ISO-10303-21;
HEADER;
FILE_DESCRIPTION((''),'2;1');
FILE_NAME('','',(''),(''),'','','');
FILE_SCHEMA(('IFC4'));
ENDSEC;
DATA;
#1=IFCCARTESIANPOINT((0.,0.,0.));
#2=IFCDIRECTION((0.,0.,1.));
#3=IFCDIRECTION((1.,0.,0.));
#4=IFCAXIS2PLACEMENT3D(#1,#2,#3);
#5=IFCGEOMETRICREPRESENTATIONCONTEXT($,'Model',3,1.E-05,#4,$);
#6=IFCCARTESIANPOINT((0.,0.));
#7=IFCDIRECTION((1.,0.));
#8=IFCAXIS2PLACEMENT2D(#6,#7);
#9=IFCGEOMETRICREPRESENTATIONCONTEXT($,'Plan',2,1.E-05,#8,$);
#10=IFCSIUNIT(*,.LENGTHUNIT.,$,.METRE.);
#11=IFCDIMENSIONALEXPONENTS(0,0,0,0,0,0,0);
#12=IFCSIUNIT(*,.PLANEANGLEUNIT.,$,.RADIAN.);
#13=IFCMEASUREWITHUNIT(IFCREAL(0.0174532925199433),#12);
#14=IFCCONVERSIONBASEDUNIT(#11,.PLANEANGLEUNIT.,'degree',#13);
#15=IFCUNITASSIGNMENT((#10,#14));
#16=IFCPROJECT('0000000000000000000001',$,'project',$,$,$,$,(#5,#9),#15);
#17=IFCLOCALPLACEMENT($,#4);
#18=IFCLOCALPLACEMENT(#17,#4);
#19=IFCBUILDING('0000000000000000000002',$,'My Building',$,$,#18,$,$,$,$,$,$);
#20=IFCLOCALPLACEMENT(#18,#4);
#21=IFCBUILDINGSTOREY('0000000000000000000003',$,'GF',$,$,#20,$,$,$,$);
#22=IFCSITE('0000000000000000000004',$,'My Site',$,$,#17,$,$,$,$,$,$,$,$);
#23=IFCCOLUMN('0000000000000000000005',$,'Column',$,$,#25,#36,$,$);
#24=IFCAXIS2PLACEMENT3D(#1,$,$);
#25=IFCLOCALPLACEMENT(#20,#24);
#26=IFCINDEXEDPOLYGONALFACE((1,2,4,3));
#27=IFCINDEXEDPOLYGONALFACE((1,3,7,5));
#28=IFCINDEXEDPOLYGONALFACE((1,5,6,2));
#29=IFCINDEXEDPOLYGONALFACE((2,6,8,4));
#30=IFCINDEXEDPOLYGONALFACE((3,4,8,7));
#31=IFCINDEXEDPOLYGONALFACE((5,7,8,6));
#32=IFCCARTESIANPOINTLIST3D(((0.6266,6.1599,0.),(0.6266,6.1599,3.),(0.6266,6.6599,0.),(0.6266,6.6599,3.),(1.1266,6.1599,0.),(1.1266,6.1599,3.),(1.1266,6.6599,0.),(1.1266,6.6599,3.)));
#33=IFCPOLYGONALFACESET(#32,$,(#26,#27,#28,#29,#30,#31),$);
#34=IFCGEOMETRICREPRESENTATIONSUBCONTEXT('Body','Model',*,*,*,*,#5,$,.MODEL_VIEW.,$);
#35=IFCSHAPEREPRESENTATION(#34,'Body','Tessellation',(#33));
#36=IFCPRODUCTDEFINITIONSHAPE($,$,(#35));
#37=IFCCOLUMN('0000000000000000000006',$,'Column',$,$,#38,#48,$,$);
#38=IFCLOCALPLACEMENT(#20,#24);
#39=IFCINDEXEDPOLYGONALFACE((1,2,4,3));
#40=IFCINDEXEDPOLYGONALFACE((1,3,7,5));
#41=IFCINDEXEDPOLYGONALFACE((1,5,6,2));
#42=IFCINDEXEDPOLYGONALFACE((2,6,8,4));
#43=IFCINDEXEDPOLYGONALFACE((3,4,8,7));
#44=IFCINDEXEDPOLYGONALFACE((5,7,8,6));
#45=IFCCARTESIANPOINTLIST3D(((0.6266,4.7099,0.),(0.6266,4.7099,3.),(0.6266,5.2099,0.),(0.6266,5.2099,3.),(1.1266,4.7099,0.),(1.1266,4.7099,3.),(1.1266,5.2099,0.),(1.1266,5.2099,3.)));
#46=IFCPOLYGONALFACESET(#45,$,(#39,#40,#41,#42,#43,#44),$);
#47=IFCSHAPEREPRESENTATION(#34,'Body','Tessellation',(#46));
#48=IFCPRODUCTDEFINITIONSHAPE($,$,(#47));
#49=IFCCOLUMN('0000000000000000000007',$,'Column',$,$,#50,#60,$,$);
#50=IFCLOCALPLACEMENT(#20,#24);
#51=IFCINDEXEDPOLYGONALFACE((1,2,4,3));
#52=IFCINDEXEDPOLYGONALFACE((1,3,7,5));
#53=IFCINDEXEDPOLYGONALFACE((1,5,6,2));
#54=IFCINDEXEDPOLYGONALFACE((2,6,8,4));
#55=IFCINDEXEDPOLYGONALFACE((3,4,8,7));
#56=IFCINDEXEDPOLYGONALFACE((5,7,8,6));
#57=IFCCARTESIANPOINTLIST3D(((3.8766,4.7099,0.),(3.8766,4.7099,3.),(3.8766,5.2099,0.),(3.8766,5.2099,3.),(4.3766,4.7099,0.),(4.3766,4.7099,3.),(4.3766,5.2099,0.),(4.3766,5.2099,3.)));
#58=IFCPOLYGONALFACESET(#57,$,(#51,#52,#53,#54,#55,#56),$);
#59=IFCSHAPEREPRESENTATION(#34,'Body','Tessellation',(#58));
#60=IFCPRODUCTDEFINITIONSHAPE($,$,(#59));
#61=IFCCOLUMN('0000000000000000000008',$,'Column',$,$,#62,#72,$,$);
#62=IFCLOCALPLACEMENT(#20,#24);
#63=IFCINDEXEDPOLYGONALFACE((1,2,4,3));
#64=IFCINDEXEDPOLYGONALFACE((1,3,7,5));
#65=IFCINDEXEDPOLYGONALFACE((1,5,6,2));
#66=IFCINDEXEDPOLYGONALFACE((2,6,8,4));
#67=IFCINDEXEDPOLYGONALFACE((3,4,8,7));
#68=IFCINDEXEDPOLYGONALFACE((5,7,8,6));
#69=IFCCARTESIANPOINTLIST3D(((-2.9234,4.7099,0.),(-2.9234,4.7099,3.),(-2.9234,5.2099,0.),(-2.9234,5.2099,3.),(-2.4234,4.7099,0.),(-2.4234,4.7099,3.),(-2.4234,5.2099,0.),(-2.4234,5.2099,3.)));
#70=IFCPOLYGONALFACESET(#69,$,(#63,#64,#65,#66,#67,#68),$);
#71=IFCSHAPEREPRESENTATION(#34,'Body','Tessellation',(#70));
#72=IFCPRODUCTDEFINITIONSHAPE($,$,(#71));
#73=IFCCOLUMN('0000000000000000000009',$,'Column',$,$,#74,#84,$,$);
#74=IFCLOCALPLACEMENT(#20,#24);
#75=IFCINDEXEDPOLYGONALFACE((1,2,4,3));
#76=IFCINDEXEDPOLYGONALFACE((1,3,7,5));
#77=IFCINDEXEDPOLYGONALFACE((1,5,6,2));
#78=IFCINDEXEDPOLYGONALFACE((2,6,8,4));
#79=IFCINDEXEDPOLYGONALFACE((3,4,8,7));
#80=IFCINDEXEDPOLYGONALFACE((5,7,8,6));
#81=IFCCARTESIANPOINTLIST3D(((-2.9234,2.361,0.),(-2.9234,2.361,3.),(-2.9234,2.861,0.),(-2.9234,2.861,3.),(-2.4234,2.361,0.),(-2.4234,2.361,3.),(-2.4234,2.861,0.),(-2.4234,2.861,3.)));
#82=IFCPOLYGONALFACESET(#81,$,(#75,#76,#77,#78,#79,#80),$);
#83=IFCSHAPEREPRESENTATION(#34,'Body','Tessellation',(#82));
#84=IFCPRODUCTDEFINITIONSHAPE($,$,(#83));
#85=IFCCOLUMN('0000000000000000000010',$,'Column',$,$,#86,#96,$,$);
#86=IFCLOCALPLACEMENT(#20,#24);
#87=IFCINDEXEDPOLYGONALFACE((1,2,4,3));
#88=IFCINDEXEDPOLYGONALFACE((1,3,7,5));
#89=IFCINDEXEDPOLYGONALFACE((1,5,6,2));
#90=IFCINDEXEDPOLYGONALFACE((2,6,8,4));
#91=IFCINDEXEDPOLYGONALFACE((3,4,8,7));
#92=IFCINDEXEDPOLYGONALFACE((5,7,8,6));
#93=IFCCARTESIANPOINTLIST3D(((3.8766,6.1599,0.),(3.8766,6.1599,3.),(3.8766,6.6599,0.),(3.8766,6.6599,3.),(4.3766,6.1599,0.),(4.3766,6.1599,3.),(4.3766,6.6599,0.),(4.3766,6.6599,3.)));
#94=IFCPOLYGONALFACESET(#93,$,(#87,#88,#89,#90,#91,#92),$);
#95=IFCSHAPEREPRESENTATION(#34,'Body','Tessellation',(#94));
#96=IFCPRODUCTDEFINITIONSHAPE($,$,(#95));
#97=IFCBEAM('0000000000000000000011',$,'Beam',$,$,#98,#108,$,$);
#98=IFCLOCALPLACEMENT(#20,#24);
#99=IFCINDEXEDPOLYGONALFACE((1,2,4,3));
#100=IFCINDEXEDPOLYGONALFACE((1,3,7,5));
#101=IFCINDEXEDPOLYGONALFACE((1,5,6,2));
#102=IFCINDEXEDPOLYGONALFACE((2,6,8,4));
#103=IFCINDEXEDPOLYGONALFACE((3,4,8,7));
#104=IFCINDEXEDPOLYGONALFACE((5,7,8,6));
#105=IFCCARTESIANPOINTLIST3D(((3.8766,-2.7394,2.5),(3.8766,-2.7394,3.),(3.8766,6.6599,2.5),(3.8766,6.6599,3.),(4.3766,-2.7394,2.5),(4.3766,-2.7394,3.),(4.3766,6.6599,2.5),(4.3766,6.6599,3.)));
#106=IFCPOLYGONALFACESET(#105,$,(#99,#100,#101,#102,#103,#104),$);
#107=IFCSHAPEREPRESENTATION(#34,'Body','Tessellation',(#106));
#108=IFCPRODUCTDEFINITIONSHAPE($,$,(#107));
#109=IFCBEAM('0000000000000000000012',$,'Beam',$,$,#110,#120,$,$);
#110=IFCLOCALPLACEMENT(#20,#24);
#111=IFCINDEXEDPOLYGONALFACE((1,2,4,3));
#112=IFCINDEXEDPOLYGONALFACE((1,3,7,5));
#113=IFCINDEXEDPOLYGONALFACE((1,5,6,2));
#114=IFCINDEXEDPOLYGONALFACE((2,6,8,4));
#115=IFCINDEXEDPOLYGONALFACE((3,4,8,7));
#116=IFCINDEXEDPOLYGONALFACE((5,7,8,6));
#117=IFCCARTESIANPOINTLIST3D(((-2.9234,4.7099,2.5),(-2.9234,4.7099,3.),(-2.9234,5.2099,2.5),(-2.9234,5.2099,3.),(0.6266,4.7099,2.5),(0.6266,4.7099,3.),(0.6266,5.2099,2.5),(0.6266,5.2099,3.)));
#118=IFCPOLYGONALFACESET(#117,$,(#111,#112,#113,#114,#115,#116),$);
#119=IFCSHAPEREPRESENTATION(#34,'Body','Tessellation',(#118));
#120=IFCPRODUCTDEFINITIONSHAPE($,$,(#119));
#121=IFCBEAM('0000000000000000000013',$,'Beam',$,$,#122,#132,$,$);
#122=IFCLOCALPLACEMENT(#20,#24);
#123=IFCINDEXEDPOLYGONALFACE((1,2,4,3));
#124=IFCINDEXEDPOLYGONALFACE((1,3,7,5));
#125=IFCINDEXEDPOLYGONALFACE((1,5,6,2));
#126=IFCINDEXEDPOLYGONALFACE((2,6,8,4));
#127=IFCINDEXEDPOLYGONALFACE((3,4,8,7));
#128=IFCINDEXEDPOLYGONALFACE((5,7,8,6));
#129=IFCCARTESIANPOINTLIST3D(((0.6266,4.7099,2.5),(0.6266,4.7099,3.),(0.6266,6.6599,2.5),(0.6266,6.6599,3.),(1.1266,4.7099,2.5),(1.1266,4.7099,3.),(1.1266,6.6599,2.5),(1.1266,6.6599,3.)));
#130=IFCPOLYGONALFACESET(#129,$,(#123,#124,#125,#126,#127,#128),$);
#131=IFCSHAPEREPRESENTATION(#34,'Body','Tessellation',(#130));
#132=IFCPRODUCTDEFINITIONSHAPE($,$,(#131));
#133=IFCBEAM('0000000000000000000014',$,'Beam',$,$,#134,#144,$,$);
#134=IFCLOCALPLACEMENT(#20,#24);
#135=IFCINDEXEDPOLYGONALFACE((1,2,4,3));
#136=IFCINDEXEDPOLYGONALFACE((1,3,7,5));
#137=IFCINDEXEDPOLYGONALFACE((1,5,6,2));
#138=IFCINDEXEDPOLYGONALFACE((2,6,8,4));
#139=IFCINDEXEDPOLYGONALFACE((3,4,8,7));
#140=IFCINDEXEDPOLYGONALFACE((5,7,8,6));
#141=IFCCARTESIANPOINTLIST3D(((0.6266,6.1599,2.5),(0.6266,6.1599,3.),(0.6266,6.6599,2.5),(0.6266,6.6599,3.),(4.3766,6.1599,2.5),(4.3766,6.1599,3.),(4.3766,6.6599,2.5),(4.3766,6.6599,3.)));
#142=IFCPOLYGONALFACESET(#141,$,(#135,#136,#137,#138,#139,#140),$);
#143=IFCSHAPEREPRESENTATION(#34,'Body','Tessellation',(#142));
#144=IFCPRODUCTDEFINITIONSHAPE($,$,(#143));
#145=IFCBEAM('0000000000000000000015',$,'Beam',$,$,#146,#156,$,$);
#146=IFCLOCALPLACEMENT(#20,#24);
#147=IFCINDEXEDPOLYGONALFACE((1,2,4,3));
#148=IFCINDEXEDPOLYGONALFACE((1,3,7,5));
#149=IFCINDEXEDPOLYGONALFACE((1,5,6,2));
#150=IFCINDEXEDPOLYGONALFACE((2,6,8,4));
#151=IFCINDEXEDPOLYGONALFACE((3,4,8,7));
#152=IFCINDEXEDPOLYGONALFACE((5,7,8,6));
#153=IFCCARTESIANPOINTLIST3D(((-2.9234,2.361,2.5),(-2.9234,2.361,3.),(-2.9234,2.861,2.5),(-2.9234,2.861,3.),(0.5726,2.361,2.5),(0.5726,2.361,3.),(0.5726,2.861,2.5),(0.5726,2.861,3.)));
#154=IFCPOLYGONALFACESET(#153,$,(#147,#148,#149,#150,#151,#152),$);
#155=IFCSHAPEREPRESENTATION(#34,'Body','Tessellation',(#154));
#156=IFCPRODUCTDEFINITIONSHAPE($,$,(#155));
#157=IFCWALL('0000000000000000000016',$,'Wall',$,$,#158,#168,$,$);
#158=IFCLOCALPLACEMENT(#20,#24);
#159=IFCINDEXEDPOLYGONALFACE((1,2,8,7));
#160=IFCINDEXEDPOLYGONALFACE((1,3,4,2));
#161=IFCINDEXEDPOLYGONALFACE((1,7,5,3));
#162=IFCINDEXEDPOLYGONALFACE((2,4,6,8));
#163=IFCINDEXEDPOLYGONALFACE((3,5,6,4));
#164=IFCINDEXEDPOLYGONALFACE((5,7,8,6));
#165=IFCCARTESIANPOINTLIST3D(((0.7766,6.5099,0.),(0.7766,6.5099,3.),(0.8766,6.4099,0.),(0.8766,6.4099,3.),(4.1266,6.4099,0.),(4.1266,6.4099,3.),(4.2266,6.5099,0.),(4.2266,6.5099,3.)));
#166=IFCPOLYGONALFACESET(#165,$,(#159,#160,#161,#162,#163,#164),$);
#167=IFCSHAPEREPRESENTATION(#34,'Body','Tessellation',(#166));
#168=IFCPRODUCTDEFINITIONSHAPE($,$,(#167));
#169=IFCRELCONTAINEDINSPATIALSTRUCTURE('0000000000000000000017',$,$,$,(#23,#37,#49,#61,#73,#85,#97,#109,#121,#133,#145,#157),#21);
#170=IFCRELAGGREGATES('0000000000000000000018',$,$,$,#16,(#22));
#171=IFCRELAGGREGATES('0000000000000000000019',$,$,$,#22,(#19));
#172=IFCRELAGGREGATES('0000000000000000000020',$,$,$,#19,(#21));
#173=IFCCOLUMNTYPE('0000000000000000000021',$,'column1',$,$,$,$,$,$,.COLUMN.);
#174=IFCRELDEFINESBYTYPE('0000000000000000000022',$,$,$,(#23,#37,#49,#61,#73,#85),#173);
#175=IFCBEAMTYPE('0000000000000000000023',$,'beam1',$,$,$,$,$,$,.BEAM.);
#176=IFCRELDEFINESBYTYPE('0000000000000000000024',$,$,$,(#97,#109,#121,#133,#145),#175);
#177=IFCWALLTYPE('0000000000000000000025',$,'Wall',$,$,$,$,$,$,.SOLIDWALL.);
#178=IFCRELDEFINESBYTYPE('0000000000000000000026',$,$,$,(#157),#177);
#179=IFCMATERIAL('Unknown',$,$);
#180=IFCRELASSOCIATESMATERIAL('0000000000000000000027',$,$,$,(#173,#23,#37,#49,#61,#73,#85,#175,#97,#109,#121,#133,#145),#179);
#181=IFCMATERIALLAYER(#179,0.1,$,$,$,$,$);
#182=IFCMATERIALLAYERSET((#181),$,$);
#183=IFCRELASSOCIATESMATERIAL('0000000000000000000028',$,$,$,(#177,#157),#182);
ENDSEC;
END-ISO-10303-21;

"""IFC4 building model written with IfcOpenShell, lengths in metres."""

from ifc_helpers import new_model, entity, si_unit, converted_unit, frame, origin_with_axes, origin_2d_with_axis, place, context, subcontext, project, spatial, line, indexed_curve, rectangle, outline, extrude, material, layer, layer_set, layer_usage, material_profile, profile_set, profile_usage, type_object, element, save


model = new_model("IFC4")

# Units and contexts
model_context = context("Model", 3, precision=1e-05, world=origin_with_axes())
plan_context = context("Plan", 2, precision=1e-05, world=origin_2d_with_axis())
body_context_1 = subcontext(model_context, "Body", "Model", "MODEL_VIEW")
ifc_project = project(units=[si_unit("LENGTHUNIT", "METRE"), converted_unit("PLANEANGLEUNIT", "degree", entity("IfcReal", 0.0174532925199433), si_unit("PLANEANGLEUNIT", "RADIAN"), dimensions=[0, 0, 0, 0, 0, 0, 0])], contexts=[model_context, plan_context])

# Site, building, storey
site_placement = place(None, origin_with_axes())
site = spatial("IfcSite", under=ifc_project, at=site_placement, Name="My Site")
building_placement = place(site_placement, origin_with_axes())
building = spatial("IfcBuilding", under=site, at=building_placement, Name="My Building")
storey_placement = place(building_placement, origin_with_axes())
storey = spatial("IfcBuildingStorey", under=building, at=storey_placement, Name="GF")

# Columns
ifc_material = material(Name="Unknown")
ifc_material_profile_1 = material_profile(ifc_material, rectangle(XDim=0.5, YDim=0.5))
ifc_profile_set_1 = profile_set([ifc_material_profile_1])
ifc_profile_usage_1 = profile_usage(ifc_profile_set_1, cardinal=5)
column_type = type_object("IfcColumnType", Name="column1", PredefinedType="COLUMN", material=ifc_profile_set_1)
column_1_placement = place(storey_placement, frame((0.8766, 6.4099, 0.0), z_axis=(0.0, 0.0, 1.0), x_axis=(1.0, 0.0, 0.0)))
element("IfcColumn", 1, at=column_1_placement, inside=storey, type_object=column_type, material=ifc_profile_usage_1, Name="Column", context=body_context_1, shape_type="SweptSolid", body=[
    extrude(rectangle(XDim=0.5, YDim=0.5), origin_with_axes(), (0.0, 0.0, 1.0), 3.0),
])
ifc_profile_usage_2 = profile_usage(ifc_profile_set_1, cardinal=5)
column_2_placement = place(storey_placement, frame((0.8766, 4.9599, 0.0), z_axis=(0.0, 0.0, 1.0), x_axis=(1.0, 0.0, 0.0)))
element("IfcColumn", 2, at=column_2_placement, inside=storey, type_object=column_type, material=ifc_profile_usage_2, Name="Column", context=body_context_1, shape_type="SweptSolid", body=[
    extrude(rectangle(XDim=0.5, YDim=0.5), origin_with_axes(), (0.0, 0.0, 1.0), 3.0),
])
ifc_profile_usage_3 = profile_usage(ifc_profile_set_1, cardinal=5)
column_3_placement = place(storey_placement, frame((4.1266, 4.9599, 0.0), z_axis=(0.0, 0.0, 1.0), x_axis=(1.0, 0.0, 0.0)))
element("IfcColumn", 3, at=column_3_placement, inside=storey, type_object=column_type, material=ifc_profile_usage_3, Name="Column", context=body_context_1, shape_type="SweptSolid", body=[
    extrude(rectangle(XDim=0.5, YDim=0.5), origin_with_axes(), (0.0, 0.0, 1.0), 3.0),
])
ifc_profile_usage_4 = profile_usage(ifc_profile_set_1, cardinal=5)
column_4_placement = place(storey_placement, frame((-2.6734, 4.9599, 0.0), z_axis=(0.0, 0.0, 1.0), x_axis=(1.0, 0.0, 0.0)))
element("IfcColumn", 4, at=column_4_placement, inside=storey, type_object=column_type, material=ifc_profile_usage_4, Name="Column", context=body_context_1, shape_type="SweptSolid", body=[
    extrude(rectangle(XDim=0.5, YDim=0.5), origin_with_axes(), (0.0, 0.0, 1.0), 3.0),
])
ifc_profile_usage_5 = profile_usage(ifc_profile_set_1, cardinal=5)
column_5_placement = place(storey_placement, frame((-2.6734, 2.611, 0.0), z_axis=(0.0, 0.0, 1.0), x_axis=(1.0, 0.0, 0.0)))
element("IfcColumn", 5, at=column_5_placement, inside=storey, type_object=column_type, material=ifc_profile_usage_5, Name="Column", context=body_context_1, shape_type="SweptSolid", body=[
    extrude(rectangle(XDim=0.5, YDim=0.5), origin_with_axes(), (0.0, 0.0, 1.0), 3.0),
])
ifc_profile_usage_6 = profile_usage(ifc_profile_set_1, cardinal=5)
column_6_placement = place(storey_placement, frame((4.1266, 6.4099, 0.0), z_axis=(0.0, 0.0, 1.0), x_axis=(1.0, 0.0, 0.0)))
element("IfcColumn", 6, at=column_6_placement, inside=storey, type_object=column_type, material=ifc_profile_usage_6, Name="Column", context=body_context_1, shape_type="SweptSolid", body=[
    extrude(rectangle(XDim=0.5, YDim=0.5), origin_with_axes(), (0.0, 0.0, 1.0), 3.0),
])

# Beams
ifc_material_profile_2 = material_profile(ifc_material, rectangle(XDim=0.5, YDim=0.5))
ifc_profile_set_2 = profile_set([ifc_material_profile_2])
ifc_profile_usage_7 = profile_usage(ifc_profile_set_2, cardinal=7)
beam_type = type_object("IfcBeamType", Name="beam1", PredefinedType="BEAM", material=ifc_profile_set_2)
beam_1_placement = place(storey_placement, frame((4.3766, 6.6599, 3.0), z_axis=(0.0, -1.0, 0.0), x_axis=(1.0, 0.0, 0.0)))
element("IfcBeam", 7, at=beam_1_placement, inside=storey, type_object=beam_type, material=ifc_profile_usage_7, Name="Beam", context=body_context_1, shape_type="SweptSolid", body=[
    extrude(rectangle(XDim=0.5, YDim=0.5), frame((-0.25, -0.25, 0.0), z_axis=(0.0, 0.0, 1.0), x_axis=(1.0, 0.0, 0.0)), (0.0, 0.0, 1.0), 9.3993),
])
ifc_profile_usage_8 = profile_usage(ifc_profile_set_2, cardinal=7)
beam_2_placement = place(storey_placement, frame((-2.9234, 5.2099, 3.0), z_axis=(1.0, -0.000001, 0.000001), x_axis=(0.000001, 1.0, 0.0)))
element("IfcBeam", 8, at=beam_2_placement, inside=storey, type_object=beam_type, material=ifc_profile_usage_8, Name="Beam", context=body_context_1, shape_type="SweptSolid", body=[
    extrude(rectangle(XDim=0.5, YDim=0.5), frame((-0.25, -0.25, 0.0), z_axis=(0.0, 0.0, 1.0), x_axis=(1.0, 0.0, 0.0)), (0.0, 0.0, 1.0), 3.55),
])
ifc_profile_usage_9 = profile_usage(ifc_profile_set_2, cardinal=7)
beam_3_placement = place(storey_placement, frame((0.6266, 4.7099, 3.0), z_axis=(0.0, 1.0, 0.0), x_axis=(-1.0, 0.0, 0.0)))
element("IfcBeam", 9, at=beam_3_placement, inside=storey, type_object=beam_type, material=ifc_profile_usage_9, Name="Beam", context=body_context_1, shape_type="SweptSolid", body=[
    extrude(rectangle(XDim=0.5, YDim=0.5), frame((-0.25, -0.25, 0.0), z_axis=(0.0, 0.0, 1.0), x_axis=(1.0, 0.0, 0.0)), (0.0, 0.0, 1.0), 1.95),
])
ifc_profile_usage_10 = profile_usage(ifc_profile_set_2, cardinal=7)
beam_4_placement = place(storey_placement, frame((0.6266, 6.6599, 3.0), z_axis=(1.0, 0.0, 0.0), x_axis=(0.0, 1.0, 0.0)))
element("IfcBeam", 10, at=beam_4_placement, inside=storey, type_object=beam_type, material=ifc_profile_usage_10, Name="Beam", context=body_context_1, shape_type="SweptSolid", body=[
    extrude(rectangle(XDim=0.5, YDim=0.5), frame((-0.25, -0.25, 0.0), z_axis=(0.0, 0.0, 1.0), x_axis=(1.0, 0.0, 0.0)), (0.0, 0.0, 1.0), 3.75),
])
ifc_profile_usage_11 = profile_usage(ifc_profile_set_2, cardinal=7)
beam_5_placement = place(storey_placement, frame((-2.9234, 2.861, 3.0), z_axis=(1.0, -0.000001, 0.000001), x_axis=(0.000001, 1.0, 0.0)))
element("IfcBeam", 11, at=beam_5_placement, inside=storey, type_object=beam_type, material=ifc_profile_usage_11, Name="Beam", context=body_context_1, shape_type="SweptSolid", body=[
    extrude(rectangle(XDim=0.5, YDim=0.5), frame((-0.25, -0.25, 0.0), z_axis=(0.0, 0.0, 1.0), x_axis=(1.0, 0.0, 0.0)), (0.0, 0.0, 1.0), 3.496),
])

# Wall
ifc_layer = layer(ifc_material, 0.1)
ifc_layer_set = layer_set([ifc_layer])
ifc_layer_usage_1 = layer_usage(ifc_layer_set, "AXIS2", "POSITIVE", 0.0)
wall_type = type_object("IfcWallType", Name="Wall", PredefinedType="SOLIDWALL", material=ifc_layer_set)
wall_1_placement = place(storey_placement, frame((4.2266, 6.5099, 0.0), z_axis=(0.0, 0.0, 1.0), x_axis=(-1.0, 0.0, 0.0)))
element("IfcWall", 12, at=wall_1_placement, inside=storey, type_object=wall_type, material=ifc_layer_usage_1, Name="Wall", context=body_context_1, shape_type="SweptSolid", body=[
    extrude(outline(indexed_curve([(0.0, 0.0), (0.1, 0.1), (3.35, 0.1), (3.45, 0.0)], segments=[line(1, 2, 3, 4, 1)])), origin_with_axes(), (0.0, 0.0, 1.0), 3.0),
])

save(model, "model.ifc")
